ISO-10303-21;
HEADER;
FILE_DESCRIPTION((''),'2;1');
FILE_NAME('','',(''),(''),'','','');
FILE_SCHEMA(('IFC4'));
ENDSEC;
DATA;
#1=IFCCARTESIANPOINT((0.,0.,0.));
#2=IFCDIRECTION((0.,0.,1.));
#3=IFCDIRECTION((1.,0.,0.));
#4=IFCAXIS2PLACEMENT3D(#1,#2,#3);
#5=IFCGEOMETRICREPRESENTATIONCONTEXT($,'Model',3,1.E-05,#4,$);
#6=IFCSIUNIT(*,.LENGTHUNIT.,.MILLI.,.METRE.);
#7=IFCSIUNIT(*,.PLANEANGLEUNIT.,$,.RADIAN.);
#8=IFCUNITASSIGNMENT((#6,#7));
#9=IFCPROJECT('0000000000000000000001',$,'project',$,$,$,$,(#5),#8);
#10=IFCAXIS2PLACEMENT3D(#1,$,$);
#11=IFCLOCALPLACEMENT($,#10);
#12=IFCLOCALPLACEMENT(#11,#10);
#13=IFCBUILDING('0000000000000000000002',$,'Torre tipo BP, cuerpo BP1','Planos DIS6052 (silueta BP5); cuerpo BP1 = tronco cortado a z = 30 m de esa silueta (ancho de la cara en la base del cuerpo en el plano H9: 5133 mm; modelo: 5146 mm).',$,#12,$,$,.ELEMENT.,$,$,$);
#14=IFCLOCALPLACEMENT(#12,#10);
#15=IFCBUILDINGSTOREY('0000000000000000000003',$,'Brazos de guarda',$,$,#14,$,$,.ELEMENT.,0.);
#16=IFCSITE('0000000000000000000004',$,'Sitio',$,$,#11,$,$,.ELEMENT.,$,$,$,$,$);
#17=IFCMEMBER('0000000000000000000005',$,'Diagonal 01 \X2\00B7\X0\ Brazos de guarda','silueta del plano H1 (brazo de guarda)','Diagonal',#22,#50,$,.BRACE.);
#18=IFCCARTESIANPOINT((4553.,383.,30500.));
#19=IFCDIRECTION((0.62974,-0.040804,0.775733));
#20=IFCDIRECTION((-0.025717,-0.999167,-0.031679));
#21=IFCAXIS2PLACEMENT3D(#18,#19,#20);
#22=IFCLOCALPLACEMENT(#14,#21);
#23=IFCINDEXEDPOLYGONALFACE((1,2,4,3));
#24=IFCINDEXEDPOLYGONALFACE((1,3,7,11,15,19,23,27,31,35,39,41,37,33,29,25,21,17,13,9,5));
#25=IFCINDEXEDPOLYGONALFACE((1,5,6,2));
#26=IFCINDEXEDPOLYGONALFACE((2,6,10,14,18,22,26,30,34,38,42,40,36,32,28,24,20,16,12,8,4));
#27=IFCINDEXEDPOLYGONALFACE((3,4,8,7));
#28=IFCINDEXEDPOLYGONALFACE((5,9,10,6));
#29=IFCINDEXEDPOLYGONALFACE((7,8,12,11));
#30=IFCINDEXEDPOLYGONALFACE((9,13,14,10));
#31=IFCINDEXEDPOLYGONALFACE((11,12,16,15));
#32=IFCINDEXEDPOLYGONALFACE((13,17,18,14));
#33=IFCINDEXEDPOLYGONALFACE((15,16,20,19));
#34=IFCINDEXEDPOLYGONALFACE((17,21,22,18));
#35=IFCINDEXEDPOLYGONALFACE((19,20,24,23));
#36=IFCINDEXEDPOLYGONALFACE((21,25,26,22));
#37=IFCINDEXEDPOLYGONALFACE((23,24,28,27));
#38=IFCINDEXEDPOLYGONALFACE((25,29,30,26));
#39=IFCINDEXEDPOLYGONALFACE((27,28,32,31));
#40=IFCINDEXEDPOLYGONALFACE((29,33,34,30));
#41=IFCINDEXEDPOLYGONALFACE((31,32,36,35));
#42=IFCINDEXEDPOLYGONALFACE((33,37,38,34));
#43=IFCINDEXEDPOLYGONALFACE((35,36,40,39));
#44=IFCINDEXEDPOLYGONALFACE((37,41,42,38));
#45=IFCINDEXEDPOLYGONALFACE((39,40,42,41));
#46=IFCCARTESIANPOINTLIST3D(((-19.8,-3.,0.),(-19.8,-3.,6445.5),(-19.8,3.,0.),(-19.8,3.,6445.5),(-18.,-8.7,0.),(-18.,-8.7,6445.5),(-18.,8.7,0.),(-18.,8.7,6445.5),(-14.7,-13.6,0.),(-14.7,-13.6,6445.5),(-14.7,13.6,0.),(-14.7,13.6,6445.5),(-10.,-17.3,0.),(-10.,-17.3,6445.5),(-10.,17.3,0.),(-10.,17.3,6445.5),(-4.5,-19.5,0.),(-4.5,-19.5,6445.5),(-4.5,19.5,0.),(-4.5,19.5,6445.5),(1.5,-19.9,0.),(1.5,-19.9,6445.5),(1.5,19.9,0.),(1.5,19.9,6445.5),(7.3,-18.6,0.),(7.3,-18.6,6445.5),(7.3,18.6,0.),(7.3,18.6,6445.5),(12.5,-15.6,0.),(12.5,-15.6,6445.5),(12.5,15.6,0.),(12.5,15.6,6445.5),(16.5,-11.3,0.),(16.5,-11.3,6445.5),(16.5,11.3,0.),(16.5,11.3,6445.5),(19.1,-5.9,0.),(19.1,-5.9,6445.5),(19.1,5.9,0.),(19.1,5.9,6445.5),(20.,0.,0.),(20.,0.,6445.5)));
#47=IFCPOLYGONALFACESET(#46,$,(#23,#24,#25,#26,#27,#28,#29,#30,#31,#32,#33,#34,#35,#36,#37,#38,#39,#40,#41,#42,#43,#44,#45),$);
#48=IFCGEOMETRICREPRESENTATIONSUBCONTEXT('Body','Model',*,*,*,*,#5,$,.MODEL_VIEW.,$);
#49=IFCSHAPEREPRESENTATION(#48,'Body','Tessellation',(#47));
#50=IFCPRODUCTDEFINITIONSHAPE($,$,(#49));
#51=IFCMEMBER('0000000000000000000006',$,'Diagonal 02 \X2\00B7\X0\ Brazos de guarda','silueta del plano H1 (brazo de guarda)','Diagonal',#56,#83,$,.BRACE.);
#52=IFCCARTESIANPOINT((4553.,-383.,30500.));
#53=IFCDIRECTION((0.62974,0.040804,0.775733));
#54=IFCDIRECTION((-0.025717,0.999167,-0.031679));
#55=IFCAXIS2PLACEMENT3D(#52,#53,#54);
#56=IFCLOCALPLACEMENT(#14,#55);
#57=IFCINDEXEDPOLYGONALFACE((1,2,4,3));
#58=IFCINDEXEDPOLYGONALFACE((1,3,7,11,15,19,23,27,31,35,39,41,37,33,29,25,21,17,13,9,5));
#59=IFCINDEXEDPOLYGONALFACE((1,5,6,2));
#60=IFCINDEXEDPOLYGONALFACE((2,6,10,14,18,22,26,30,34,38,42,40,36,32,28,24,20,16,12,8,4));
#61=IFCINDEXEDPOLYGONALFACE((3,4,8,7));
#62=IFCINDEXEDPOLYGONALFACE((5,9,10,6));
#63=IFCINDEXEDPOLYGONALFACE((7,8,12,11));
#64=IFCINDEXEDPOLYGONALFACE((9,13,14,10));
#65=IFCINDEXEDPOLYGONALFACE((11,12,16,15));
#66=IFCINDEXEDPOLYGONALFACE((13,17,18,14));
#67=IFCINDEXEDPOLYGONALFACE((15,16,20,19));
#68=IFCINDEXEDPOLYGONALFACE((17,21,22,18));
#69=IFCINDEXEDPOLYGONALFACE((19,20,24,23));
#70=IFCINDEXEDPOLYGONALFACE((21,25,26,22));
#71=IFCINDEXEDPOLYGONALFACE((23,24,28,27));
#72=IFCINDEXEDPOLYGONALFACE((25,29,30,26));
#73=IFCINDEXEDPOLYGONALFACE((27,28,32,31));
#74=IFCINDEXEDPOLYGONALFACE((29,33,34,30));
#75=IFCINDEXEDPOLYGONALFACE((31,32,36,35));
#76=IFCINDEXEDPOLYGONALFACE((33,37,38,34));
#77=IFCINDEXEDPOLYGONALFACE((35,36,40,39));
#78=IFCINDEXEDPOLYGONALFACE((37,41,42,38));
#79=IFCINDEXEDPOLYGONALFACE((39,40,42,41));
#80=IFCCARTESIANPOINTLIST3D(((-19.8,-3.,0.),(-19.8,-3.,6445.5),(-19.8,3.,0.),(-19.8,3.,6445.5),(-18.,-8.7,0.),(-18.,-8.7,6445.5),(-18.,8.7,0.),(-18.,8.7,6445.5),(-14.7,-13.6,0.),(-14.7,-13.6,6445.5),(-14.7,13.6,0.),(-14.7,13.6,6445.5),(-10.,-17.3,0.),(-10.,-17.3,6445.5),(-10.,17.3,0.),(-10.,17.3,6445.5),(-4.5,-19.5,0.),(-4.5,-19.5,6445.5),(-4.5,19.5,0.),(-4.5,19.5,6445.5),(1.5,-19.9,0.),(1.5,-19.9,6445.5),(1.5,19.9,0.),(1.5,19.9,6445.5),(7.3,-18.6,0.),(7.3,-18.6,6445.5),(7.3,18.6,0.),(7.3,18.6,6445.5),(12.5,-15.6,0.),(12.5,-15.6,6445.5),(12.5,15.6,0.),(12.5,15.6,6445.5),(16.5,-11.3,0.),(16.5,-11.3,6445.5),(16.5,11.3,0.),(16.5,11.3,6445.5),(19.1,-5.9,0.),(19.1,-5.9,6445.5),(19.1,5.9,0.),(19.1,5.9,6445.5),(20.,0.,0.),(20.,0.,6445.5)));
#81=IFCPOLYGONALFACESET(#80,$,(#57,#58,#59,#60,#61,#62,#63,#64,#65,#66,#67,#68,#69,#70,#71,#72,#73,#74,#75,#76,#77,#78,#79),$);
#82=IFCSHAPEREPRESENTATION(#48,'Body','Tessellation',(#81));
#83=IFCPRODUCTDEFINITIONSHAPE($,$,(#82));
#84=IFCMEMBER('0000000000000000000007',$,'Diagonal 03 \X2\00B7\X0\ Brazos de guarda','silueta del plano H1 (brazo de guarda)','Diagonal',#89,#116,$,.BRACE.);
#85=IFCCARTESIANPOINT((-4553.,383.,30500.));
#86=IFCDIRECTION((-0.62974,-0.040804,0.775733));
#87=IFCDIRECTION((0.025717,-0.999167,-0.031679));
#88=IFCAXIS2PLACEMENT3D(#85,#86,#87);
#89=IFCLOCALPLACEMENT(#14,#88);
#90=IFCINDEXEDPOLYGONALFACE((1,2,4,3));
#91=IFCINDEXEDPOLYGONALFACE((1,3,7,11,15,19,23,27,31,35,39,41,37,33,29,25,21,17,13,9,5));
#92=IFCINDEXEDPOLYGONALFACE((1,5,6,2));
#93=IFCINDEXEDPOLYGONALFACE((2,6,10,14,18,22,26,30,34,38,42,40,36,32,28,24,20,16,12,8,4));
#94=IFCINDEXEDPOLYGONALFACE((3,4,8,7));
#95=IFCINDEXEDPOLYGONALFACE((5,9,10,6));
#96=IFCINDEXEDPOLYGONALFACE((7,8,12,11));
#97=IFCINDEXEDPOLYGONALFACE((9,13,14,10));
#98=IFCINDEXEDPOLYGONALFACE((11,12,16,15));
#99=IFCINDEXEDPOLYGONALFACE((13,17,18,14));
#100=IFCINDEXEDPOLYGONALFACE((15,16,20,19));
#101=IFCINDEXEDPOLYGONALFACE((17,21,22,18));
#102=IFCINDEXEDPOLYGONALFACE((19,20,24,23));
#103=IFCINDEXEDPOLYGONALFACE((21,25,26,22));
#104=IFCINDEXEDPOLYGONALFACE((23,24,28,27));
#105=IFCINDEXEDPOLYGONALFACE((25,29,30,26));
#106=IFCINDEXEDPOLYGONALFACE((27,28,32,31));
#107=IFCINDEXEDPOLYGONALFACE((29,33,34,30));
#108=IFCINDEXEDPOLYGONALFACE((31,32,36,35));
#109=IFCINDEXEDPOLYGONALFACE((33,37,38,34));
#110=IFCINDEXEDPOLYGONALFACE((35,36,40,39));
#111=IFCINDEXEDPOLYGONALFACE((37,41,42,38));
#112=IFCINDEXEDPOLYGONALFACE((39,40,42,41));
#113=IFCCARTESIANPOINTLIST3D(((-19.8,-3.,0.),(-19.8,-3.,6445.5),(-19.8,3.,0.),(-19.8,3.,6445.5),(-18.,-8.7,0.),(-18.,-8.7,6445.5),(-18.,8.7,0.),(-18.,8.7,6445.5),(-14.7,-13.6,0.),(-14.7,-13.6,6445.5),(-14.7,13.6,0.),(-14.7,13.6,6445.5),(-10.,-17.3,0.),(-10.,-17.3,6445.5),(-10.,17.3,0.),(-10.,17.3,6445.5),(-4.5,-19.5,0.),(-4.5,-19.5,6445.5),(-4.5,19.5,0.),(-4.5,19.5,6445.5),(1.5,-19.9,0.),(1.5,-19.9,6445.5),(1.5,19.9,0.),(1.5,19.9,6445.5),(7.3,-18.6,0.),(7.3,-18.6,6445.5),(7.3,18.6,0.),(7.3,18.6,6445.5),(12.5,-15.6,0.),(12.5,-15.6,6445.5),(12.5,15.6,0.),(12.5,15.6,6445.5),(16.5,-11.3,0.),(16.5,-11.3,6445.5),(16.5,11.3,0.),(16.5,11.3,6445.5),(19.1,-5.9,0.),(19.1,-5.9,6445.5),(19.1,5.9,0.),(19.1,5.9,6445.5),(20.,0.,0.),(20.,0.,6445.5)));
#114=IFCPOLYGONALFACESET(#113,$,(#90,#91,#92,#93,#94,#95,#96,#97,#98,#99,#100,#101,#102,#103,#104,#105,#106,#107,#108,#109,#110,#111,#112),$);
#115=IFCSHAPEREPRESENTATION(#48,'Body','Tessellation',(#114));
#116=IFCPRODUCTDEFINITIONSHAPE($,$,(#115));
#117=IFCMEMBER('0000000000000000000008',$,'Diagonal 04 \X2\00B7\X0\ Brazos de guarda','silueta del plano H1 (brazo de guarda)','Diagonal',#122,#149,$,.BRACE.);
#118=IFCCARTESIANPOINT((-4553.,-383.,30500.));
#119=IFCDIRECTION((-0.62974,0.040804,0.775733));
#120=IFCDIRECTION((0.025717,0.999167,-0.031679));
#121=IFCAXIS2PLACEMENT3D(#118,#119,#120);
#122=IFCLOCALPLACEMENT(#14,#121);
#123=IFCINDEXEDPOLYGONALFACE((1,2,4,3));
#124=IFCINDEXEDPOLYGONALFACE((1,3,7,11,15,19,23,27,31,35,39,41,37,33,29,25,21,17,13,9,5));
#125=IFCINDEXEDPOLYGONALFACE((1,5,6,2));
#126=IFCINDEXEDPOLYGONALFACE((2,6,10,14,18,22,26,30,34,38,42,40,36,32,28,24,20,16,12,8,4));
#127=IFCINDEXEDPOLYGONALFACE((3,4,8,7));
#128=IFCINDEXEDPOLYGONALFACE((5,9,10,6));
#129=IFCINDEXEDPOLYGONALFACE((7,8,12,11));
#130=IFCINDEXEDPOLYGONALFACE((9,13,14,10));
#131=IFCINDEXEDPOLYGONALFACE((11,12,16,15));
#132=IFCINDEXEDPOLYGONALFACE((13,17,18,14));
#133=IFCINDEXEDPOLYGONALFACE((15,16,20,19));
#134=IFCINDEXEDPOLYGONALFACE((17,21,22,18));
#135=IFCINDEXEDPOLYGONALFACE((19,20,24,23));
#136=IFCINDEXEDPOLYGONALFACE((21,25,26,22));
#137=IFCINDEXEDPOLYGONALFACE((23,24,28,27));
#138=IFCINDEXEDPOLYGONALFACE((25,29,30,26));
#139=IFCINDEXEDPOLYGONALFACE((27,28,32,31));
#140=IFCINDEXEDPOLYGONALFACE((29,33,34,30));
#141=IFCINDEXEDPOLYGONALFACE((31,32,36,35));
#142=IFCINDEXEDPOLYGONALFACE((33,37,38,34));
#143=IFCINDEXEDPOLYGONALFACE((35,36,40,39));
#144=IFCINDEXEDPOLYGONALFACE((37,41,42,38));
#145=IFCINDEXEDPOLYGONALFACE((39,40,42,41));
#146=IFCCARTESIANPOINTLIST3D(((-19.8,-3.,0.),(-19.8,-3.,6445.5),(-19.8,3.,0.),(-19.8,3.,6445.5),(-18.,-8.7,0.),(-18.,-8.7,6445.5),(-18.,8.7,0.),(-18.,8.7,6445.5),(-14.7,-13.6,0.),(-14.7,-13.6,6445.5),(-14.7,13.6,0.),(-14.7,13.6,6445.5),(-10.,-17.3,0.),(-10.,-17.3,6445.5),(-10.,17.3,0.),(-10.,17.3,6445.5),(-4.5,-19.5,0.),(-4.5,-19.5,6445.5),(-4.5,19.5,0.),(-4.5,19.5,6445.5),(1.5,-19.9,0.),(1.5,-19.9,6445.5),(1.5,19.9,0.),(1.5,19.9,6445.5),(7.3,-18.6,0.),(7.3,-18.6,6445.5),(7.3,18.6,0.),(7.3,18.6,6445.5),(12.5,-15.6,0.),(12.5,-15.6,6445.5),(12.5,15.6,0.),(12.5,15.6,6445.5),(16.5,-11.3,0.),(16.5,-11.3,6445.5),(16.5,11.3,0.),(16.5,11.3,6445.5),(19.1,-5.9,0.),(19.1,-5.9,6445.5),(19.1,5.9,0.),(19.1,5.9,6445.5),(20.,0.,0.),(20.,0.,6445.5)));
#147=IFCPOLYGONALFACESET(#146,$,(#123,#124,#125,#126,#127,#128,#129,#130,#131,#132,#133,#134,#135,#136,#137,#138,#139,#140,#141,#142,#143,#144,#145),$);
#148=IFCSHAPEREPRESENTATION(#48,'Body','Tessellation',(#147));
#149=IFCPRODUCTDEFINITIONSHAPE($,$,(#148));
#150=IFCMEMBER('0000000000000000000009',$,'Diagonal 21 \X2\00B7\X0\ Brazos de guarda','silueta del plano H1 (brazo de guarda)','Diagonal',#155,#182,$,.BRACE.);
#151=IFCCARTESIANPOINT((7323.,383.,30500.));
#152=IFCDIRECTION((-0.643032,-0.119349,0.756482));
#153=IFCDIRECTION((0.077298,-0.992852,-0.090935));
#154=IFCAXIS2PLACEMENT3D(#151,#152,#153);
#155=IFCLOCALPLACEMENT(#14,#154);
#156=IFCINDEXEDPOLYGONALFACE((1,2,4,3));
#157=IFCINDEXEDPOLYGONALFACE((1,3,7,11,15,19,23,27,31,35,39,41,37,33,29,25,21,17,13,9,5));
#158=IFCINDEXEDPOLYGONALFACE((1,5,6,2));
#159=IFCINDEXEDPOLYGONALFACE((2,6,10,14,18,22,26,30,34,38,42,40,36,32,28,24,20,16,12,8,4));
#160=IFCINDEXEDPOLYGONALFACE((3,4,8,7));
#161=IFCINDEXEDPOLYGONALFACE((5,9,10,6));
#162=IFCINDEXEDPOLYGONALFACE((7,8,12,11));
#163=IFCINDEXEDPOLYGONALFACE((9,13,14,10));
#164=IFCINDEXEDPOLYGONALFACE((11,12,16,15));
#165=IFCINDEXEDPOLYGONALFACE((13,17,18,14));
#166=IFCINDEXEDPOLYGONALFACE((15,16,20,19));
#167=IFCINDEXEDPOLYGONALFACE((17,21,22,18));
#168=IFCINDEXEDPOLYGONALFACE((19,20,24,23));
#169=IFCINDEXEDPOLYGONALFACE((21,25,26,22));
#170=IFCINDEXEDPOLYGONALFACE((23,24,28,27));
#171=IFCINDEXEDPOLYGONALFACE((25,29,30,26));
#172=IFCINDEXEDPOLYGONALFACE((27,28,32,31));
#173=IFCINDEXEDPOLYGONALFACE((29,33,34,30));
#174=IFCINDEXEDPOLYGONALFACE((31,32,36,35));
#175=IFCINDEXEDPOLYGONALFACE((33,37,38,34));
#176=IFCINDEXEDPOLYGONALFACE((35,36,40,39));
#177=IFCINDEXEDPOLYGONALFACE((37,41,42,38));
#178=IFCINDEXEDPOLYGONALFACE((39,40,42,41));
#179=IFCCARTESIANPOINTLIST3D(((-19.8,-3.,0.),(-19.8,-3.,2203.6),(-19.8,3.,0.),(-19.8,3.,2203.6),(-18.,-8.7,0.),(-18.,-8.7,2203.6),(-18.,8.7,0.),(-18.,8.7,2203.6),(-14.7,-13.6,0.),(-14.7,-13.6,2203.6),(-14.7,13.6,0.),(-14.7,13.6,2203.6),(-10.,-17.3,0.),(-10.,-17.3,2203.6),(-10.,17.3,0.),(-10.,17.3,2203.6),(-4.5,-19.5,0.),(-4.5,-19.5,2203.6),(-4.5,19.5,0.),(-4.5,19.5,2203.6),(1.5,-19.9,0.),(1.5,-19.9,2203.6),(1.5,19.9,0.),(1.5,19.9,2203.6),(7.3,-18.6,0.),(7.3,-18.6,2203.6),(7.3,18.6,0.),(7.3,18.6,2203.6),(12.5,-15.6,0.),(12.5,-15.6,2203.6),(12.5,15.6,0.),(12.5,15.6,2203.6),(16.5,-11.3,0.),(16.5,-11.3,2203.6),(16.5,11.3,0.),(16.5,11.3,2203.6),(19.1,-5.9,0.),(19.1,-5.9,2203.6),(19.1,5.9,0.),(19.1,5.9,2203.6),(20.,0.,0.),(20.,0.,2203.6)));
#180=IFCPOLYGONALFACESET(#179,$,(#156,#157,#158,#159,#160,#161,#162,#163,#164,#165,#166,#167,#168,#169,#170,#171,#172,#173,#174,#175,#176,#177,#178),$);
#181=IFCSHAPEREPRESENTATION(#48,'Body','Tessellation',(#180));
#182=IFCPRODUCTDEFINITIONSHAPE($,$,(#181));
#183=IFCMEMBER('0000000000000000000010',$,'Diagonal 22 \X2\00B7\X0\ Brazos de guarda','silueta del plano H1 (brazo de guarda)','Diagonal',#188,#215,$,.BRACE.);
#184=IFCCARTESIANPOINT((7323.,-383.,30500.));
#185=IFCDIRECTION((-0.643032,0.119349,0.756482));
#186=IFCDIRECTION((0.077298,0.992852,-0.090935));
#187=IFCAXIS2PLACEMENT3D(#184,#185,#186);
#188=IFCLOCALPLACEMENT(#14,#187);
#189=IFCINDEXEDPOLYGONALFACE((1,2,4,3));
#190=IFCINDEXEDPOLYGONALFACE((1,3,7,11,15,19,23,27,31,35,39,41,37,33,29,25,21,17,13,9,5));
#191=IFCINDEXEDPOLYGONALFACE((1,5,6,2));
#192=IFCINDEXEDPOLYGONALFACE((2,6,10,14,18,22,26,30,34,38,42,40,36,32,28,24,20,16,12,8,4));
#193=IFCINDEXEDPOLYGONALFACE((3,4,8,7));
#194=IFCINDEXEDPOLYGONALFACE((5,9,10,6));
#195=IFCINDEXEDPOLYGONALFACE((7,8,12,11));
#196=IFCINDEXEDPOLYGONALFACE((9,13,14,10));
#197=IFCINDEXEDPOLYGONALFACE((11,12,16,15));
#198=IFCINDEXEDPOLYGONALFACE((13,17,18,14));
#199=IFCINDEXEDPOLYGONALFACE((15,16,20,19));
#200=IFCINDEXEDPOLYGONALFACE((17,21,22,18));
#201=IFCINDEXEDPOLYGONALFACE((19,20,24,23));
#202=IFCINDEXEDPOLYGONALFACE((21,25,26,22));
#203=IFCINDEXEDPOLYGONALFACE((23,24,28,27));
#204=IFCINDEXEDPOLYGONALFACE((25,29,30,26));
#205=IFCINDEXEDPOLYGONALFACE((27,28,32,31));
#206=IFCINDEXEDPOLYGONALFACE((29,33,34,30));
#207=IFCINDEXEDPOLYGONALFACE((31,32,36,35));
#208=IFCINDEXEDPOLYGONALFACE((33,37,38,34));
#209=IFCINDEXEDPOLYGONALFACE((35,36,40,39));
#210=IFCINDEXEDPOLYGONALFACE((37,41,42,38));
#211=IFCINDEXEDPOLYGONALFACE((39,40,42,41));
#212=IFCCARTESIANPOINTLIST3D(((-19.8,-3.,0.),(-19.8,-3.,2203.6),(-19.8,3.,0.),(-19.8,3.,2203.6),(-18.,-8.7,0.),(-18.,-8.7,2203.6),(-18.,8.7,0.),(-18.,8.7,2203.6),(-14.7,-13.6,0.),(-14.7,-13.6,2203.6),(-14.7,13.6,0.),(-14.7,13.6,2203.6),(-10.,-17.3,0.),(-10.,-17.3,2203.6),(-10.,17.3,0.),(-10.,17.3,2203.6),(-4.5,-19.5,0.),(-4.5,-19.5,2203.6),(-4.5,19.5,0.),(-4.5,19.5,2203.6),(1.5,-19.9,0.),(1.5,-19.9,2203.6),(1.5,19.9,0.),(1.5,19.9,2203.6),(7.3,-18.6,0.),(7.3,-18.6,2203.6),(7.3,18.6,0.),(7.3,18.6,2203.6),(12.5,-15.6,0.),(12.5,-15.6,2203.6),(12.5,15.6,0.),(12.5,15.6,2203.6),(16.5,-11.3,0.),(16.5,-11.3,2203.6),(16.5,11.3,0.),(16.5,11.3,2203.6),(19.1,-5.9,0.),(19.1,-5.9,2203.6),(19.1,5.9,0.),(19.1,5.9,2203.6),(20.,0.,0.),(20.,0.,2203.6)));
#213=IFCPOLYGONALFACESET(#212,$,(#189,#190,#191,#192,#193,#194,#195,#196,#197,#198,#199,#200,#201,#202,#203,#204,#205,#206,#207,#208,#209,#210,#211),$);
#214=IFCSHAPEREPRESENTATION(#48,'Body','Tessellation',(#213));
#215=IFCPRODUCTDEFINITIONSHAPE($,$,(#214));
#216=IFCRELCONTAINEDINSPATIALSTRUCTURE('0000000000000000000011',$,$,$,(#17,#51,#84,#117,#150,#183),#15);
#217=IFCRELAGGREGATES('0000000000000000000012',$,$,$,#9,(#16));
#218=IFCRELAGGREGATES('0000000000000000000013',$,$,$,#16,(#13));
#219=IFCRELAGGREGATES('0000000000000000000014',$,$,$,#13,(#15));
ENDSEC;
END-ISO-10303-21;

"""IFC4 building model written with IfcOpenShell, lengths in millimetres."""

from ifc_helpers import new_model, si_unit, frame, origin, origin_with_axes, place, context, subcontext, project, spatial, circle, extrude, element, save


model = new_model("IFC4")

# Units and contexts
model_context = context("Model", 3, precision=1e-05, world=origin_with_axes())
body_context = subcontext(model_context, "Body", "Model", "MODEL_VIEW")
ifc_project = project(units=[si_unit("LENGTHUNIT", "METRE", prefix="MILLI"), si_unit("PLANEANGLEUNIT", "RADIAN")], contexts=[model_context])

# Site, building, storey
site_placement = place(None, origin())
site = spatial("IfcSite", under=ifc_project, at=site_placement, Name="Sitio", CompositionType="ELEMENT")
building_placement = place(site_placement, origin())
building = spatial("IfcBuilding", under=site, at=building_placement, Name="Torre tipo BP, cuerpo BP1", Description="Planos DIS6052 (silueta BP5); cuerpo BP1 = tronco cortado a z = 30 m de esa silueta (ancho de la cara en la base del cuerpo en el plano H9: 5133 mm; modelo: 5146 mm).", CompositionType="ELEMENT")
storey_placement = place(building_placement, origin())
storey = spatial("IfcBuildingStorey", under=building, at=storey_placement, Name="Brazos de guarda", CompositionType="ELEMENT", Elevation=0.0)

# Members
for number, where, z_axis, x_axis, name in (
    (1, (4553.0, 383.0, 30500.0), (0.62974, -0.040804, 0.775733), (-0.025717, -0.999167, -0.031679), "Diagonal 01 · Brazos de guarda"),
    (2, (4553.0, -383.0, 30500.0), (0.62974, 0.040804, 0.775733), (-0.025717, 0.999167, -0.031679), "Diagonal 02 · Brazos de guarda"),
    (3, (-4553.0, 383.0, 30500.0), (-0.62974, -0.040804, 0.775733), (0.025717, -0.999167, -0.031679), "Diagonal 03 · Brazos de guarda"),
    (4, (-4553.0, -383.0, 30500.0), (-0.62974, 0.040804, 0.775733), (0.025717, 0.999167, -0.031679), "Diagonal 04 · Brazos de guarda"),
):
    element("IfcMember", number, at=place(storey_placement, frame(where, z_axis=z_axis, x_axis=x_axis)), inside=storey, Name=name, Description="silueta del plano H1 (brazo de guarda)", ObjectType="Diagonal", PredefinedType="BRACE", context=body_context, shape_type="SweptSolid", body=[
        extrude(circle(Radius=20.0), None, (0.0, 0.0, 1.0), 6445.5),
    ])
for number, where, z_axis, x_axis, name in (
    (5, (7323.0, 383.0, 30500.0), (-0.643032, -0.119349, 0.756482), (0.077298, -0.992852, -0.090935), "Diagonal 21 · Brazos de guarda"),
    (6, (7323.0, -383.0, 30500.0), (-0.643032, 0.119349, 0.756482), (0.077298, 0.992852, -0.090935), "Diagonal 22 · Brazos de guarda"),
):
    element("IfcMember", number, at=place(storey_placement, frame(where, z_axis=z_axis, x_axis=x_axis)), inside=storey, Name=name, Description="silueta del plano H1 (brazo de guarda)", ObjectType="Diagonal", PredefinedType="BRACE", context=body_context, shape_type="SweptSolid", body=[
        extrude(circle(Radius=20.0), None, (0.0, 0.0, 1.0), 2203.6),
    ])

save(model, "model.ifc")
